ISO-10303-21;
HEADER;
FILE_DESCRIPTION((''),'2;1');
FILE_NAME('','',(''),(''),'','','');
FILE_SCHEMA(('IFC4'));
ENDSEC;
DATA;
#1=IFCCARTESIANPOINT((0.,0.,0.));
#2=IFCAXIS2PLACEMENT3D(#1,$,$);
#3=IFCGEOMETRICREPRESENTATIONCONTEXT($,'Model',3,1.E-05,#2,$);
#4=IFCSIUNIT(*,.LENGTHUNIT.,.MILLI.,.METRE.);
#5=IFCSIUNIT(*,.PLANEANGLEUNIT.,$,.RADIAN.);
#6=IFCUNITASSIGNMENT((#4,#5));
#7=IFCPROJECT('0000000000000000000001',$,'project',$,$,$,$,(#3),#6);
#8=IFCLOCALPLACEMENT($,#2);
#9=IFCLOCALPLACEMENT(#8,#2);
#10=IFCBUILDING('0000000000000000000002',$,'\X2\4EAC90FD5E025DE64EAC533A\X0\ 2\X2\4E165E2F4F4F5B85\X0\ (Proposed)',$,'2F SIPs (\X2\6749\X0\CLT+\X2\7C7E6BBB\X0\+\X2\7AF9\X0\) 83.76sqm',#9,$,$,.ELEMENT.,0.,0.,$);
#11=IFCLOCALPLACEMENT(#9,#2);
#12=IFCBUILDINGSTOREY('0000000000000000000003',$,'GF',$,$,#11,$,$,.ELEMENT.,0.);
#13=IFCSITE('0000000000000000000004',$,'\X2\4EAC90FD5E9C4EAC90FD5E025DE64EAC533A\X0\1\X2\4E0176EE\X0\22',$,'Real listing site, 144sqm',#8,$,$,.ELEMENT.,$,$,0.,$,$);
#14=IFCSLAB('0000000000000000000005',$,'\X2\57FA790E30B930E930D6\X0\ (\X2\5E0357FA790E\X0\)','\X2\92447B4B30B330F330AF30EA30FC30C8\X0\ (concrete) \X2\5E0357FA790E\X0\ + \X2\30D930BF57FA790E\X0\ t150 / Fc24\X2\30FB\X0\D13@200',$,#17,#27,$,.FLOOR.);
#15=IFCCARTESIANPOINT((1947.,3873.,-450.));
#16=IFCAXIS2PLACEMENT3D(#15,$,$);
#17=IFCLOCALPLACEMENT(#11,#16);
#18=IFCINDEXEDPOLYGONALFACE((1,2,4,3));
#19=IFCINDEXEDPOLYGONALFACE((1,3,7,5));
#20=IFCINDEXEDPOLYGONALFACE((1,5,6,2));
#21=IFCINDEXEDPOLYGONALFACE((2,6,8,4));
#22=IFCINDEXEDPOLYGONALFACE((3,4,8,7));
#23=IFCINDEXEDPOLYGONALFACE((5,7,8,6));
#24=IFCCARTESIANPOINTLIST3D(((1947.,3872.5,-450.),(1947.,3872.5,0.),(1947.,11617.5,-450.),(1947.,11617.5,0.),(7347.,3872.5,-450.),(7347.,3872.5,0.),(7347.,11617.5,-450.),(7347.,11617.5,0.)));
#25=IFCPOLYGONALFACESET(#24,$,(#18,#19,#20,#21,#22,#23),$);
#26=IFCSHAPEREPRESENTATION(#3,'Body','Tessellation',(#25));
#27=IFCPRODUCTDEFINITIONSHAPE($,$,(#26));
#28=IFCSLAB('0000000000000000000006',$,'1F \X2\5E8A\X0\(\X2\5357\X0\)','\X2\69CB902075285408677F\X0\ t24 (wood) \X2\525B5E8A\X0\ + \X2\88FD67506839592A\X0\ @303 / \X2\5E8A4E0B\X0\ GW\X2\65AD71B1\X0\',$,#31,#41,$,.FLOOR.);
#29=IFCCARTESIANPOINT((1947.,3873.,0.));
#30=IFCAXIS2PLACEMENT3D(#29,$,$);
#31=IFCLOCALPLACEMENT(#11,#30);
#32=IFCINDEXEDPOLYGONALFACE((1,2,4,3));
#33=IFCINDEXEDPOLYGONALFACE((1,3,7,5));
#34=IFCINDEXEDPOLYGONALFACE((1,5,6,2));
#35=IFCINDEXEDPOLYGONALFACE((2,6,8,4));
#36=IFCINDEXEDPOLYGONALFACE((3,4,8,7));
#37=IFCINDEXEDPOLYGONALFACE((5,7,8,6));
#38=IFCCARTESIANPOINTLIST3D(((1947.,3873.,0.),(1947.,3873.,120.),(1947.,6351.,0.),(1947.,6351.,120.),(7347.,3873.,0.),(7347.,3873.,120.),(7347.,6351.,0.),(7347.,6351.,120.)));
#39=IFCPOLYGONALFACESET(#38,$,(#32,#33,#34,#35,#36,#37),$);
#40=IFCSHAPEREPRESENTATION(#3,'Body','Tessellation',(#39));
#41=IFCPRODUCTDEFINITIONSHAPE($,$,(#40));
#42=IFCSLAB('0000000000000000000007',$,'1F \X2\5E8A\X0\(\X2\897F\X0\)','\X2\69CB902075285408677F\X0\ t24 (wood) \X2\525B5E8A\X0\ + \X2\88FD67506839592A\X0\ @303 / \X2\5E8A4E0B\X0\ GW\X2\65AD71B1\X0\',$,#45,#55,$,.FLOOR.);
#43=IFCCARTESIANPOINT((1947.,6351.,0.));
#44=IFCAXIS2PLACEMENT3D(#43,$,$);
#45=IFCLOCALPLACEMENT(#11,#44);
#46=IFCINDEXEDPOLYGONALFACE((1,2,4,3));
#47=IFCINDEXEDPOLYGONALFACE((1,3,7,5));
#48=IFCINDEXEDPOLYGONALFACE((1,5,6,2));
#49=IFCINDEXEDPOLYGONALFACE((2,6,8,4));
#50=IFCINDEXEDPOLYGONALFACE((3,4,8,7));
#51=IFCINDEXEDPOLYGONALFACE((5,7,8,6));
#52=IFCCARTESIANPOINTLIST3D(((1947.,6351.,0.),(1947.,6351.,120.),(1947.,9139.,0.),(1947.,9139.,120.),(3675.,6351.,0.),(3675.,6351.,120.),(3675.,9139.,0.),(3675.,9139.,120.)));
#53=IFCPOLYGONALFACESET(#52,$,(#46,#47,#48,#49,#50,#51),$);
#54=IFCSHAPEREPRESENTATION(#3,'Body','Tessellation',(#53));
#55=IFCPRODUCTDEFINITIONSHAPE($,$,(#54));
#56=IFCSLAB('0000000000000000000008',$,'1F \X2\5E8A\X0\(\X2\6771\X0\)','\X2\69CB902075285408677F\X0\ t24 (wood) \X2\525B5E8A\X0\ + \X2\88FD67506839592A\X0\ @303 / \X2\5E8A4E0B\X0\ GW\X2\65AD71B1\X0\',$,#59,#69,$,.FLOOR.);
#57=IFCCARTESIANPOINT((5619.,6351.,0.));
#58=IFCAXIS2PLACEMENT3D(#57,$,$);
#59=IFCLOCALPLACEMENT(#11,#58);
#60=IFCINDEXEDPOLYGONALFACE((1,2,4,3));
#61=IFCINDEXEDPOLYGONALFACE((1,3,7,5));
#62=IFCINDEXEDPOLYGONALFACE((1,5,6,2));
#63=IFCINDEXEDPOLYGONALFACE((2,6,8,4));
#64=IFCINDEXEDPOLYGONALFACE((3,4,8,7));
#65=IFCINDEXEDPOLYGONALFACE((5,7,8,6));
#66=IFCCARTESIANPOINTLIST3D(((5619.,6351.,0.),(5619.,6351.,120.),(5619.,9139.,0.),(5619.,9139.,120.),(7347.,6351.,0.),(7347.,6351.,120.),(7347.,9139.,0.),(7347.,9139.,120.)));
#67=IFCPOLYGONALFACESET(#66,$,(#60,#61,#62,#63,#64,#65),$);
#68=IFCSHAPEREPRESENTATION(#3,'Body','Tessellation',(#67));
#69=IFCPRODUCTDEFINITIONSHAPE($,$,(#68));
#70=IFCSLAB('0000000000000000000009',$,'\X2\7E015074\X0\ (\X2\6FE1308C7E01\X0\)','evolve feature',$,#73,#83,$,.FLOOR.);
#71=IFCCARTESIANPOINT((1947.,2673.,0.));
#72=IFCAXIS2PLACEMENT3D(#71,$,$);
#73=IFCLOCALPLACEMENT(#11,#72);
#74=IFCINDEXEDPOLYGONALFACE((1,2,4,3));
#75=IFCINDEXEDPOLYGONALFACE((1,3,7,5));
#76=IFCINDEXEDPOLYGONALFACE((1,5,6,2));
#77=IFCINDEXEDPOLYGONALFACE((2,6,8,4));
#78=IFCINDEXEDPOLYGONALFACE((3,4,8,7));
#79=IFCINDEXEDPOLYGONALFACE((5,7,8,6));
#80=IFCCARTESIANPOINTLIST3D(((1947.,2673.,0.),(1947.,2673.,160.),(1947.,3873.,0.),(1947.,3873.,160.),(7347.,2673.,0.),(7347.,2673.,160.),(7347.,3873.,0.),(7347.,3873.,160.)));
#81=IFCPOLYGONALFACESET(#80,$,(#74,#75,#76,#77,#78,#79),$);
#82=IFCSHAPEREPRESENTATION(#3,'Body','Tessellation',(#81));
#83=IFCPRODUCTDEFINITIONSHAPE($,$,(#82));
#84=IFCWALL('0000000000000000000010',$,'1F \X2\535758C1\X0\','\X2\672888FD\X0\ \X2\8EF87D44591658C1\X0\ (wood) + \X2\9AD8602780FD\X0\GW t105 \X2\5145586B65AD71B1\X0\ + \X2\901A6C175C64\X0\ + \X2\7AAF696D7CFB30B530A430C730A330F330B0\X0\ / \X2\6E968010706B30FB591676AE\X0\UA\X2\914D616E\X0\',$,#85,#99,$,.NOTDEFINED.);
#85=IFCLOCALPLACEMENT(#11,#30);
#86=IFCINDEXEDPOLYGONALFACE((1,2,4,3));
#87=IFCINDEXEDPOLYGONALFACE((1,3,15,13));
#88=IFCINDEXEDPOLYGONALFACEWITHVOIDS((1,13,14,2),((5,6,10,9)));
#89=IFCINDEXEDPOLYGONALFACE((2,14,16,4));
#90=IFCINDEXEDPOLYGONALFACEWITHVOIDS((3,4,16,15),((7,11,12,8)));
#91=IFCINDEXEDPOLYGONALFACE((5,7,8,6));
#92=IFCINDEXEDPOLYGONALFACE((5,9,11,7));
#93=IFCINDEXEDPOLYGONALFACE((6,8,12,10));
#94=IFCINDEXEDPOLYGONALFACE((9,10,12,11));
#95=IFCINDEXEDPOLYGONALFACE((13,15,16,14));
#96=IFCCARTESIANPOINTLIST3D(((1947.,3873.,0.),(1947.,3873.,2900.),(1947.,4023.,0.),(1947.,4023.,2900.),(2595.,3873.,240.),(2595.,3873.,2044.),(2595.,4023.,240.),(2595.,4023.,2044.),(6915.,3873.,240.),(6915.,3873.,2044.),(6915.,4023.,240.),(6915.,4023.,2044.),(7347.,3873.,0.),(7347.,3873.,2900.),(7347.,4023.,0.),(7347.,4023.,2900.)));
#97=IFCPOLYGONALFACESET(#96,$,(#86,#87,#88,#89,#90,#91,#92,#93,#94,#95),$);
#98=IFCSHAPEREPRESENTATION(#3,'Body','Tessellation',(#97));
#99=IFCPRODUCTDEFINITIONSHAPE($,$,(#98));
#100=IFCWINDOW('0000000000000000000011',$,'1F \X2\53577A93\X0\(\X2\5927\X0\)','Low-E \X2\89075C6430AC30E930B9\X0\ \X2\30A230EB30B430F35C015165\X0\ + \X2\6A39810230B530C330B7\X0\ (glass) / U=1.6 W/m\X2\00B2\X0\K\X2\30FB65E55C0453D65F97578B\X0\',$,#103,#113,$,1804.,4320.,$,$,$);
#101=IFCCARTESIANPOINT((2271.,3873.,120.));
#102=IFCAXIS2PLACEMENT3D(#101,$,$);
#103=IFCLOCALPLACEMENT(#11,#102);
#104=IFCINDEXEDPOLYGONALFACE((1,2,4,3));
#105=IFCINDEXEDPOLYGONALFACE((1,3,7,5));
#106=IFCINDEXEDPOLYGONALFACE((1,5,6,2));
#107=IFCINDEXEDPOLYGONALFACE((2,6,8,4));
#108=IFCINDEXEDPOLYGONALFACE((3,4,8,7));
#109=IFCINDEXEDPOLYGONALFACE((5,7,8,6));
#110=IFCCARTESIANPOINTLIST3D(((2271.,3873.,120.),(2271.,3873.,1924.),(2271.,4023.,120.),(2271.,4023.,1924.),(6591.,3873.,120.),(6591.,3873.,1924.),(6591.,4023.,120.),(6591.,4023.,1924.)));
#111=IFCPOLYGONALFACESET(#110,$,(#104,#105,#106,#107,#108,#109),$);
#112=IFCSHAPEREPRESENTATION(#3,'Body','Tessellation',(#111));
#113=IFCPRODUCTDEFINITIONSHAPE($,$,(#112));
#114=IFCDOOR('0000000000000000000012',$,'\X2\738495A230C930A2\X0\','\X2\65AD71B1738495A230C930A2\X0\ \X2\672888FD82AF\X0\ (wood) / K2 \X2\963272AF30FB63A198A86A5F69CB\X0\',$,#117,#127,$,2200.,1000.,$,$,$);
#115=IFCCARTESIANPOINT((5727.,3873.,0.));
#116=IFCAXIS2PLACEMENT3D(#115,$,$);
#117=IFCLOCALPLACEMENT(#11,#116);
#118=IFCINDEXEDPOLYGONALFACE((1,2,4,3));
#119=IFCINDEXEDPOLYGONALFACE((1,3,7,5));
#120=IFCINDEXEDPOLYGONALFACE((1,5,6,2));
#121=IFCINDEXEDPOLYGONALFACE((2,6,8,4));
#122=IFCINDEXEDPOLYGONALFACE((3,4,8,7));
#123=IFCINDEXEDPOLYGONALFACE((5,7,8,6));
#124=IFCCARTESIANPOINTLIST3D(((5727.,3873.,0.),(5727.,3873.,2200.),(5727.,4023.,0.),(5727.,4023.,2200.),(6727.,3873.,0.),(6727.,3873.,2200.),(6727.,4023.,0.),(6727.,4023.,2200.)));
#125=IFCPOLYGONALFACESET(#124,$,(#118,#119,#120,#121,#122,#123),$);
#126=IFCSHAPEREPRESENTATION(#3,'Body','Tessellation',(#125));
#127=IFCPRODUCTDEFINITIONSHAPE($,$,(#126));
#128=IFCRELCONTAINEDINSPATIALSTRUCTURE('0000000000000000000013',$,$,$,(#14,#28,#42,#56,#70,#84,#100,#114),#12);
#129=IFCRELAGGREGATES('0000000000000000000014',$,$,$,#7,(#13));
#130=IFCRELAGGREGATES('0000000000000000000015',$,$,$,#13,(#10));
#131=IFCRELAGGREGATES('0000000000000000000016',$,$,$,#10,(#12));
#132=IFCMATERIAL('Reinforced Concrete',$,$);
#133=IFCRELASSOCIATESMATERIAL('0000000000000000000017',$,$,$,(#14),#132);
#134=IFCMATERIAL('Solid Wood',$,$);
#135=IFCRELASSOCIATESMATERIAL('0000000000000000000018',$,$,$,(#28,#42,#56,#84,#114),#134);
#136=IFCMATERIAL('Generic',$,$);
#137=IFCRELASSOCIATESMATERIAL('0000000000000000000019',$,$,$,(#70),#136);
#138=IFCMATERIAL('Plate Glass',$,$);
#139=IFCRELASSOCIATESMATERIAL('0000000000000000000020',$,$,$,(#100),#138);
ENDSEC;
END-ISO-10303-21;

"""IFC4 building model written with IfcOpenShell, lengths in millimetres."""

from ifc_helpers import new_model, si_unit, frame, frame_2d, origin, place, context, project, spatial, rectangle, extrude, material, element, fill, save


model = new_model("IFC4")

# Units and contexts
model_context = context("Model", 3, precision=1e-05, world=origin())
ifc_project = project(units=[si_unit("LENGTHUNIT", "METRE", prefix="MILLI"), si_unit("PLANEANGLEUNIT", "RADIAN")], contexts=[model_context])

# Site, building, storey
site_placement = place(None, origin())
site = spatial("IfcSite", under=ifc_project, at=site_placement, Name="京都府京都市左京区1丁目22", ObjectType="Real listing site, 144sqm", CompositionType="ELEMENT", RefElevation=0.0)
building_placement = place(site_placement, origin())
building = spatial("IfcBuilding", under=site, at=building_placement, Name="京都市左京区 2世帯住宅 (Proposed)", ObjectType="2F SIPs (杉CLT+籾殻+竹) 83.76sqm", CompositionType="ELEMENT", ElevationOfRefHeight=0.0, ElevationOfTerrain=0.0)
storey_placement = place(building_placement, origin())
storey = spatial("IfcBuildingStorey", under=building, at=storey_placement, Name="GF", CompositionType="ELEMENT", Elevation=0.0)

# Slabs
ifc_material_1 = material(Name="Reinforced Concrete")
slab_1_placement = place(storey_placement, frame((1947.0, 3873.0, -450.0)))
element("IfcSlab", 1, at=slab_1_placement, inside=storey, material=ifc_material_1, Name="基礎スラブ (布基礎)", Description="鉄筋コンクリート (concrete) 布基礎 + ベタ基礎 t150 / Fc24・D13@200", PredefinedType="FLOOR", context=model_context, shape_type="SweptSolid", body=[
    extrude(rectangle(XDim=5400.0, YDim=7745.0, at=frame_2d((2700.0, 3872.0))), frame((1947.0, 3873.0, -450.0)), (0.0, 0.0, 1.0), 450.0),
])
ifc_material_2 = material(Name="Solid Wood")
slab_2_placement = place(storey_placement, frame((1947.0, 3873.0, 0.0)))
element("IfcSlab", 2, at=slab_2_placement, inside=storey, material=ifc_material_2, Name="1F 床(南)", Description="構造用合板 t24 (wood) 剛床 + 製材根太 @303 / 床下 GW断熱", PredefinedType="FLOOR", context=model_context, shape_type="SweptSolid", body=[
    extrude(rectangle(XDim=5400.0, YDim=2478.0, at=frame_2d((2700.0, 1239.0))), frame((1947.0, 3873.0, 0.0)), (0.0, 0.0, 1.0), 120.0),
])
slab_3_placement = place(storey_placement, frame((1947.0, 6351.0, 0.0)))
element("IfcSlab", 3, at=slab_3_placement, inside=storey, material=ifc_material_2, Name="1F 床(西)", Description="構造用合板 t24 (wood) 剛床 + 製材根太 @303 / 床下 GW断熱", PredefinedType="FLOOR", context=model_context, shape_type="SweptSolid", body=[
    extrude(rectangle(XDim=1728.0, YDim=2788.0, at=frame_2d((864.0, 1394.0))), frame((1947.0, 6351.0, 0.0)), (0.0, 0.0, 1.0), 120.0),
])
slab_4_placement = place(storey_placement, frame((5619.0, 6351.0, 0.0)))
element("IfcSlab", 4, at=slab_4_placement, inside=storey, material=ifc_material_2, Name="1F 床(東)", Description="構造用合板 t24 (wood) 剛床 + 製材根太 @303 / 床下 GW断熱", PredefinedType="FLOOR", context=model_context, shape_type="SweptSolid", body=[
    extrude(rectangle(XDim=1728.0, YDim=2788.0, at=frame_2d((864.0, 1394.0))), frame((5619.0, 6351.0, 0.0)), (0.0, 0.0, 1.0), 120.0),
])
ifc_material_3 = material(Name="Generic")
slab_5_placement = place(storey_placement, frame((1947.0, 2673.0, 0.0)))
element("IfcSlab", 5, at=slab_5_placement, inside=storey, material=ifc_material_3, Name="縁側 (濡れ縁)", Description="evolve feature", PredefinedType="FLOOR", context=model_context, shape_type="SweptSolid", body=[
    extrude(rectangle(XDim=5400.0, YDim=1200.0, at=frame_2d((2700.0, 600.0))), frame((1947.0, 2673.0, 0.0)), (0.0, 0.0, 1.0), 160.0),
])

# Wall, openings, window, door
wall_1_placement = place(storey_placement, frame((1947.0, 3873.0, 0.0)))
wall_1 = element("IfcWall", 6, at=wall_1_placement, inside=storey, material=ifc_material_2, Name="1F 南壁", Description="木製 軸組外壁 (wood) + 高性能GW t105 充填断熱 + 通気層 + 窯業系サイディング / 準耐火・外皮UA配慮", PredefinedType="NOTDEFINED", context=model_context, shape_type="SweptSolid", body=[
    extrude(rectangle(XDim=5400.0, YDim=150.0, at=frame_2d((2700.0, 75.0))), frame((1947.0, 3873.0, 0.0)), (0.0, 0.0, 1.0), 2900.0),
])
opening_1_placement = place(storey_placement, frame((2271.0, 3873.0, 120.0)))
opening_1 = element("IfcOpeningElement", 7, at=opening_1_placement, cuts=wall_1, PredefinedType="NOTDEFINED", context=model_context, shape_type="SweptSolid", body=[
    extrude(rectangle(XDim=4320.0, YDim=150.0, at=frame_2d((2160.0, 75.0))), frame((2271.0, 3873.0, 120.0)), (0.0, 0.0, 1.0), 1804.0),
])
opening_2_placement = place(storey_placement, frame((5727.0, 3873.0, 0.0)))
opening_2 = element("IfcOpeningElement", 8, at=opening_2_placement, cuts=wall_1, PredefinedType="NOTDEFINED", context=model_context, shape_type="SweptSolid", body=[
    extrude(rectangle(XDim=1000.0, YDim=150.0, at=frame_2d((500.0, 75.0))), frame((5727.0, 3873.0, 0.0)), (0.0, 0.0, 1.0), 2200.0),
])
ifc_material_4 = material(Name="Plate Glass")
window_1_placement = place(storey_placement, frame((2271.0, 3873.0, 120.0)))
window_1 = element("IfcWindow", 9, at=window_1_placement, inside=storey, material=ifc_material_4, Name="1F 南窓(大)", Description="Low-E 複層ガラス アルゴン封入 + 樹脂サッシ (glass) / U=1.6 W/m²K・日射取得型", OverallHeight=1804.0, OverallWidth=4320.0, context=model_context, shape_type="SweptSolid", body=[
    extrude(rectangle(XDim=4320.0, YDim=150.0, at=frame_2d((2160.0, 75.0))), frame((2271.0, 3873.0, 120.0)), (0.0, 0.0, 1.0), 1804.0),
])
fill(opening_1, window_1)
door_placement = place(storey_placement, frame((5727.0, 3873.0, 0.0)))
door = element("IfcDoor", 10, at=door_placement, inside=storey, material=ifc_material_2, Name="玄関ドア", Description="断熱玄関ドア 木製芯 (wood) / K2 防犯・採風機構", OverallHeight=2200.0, OverallWidth=1000.0, context=model_context, shape_type="SweptSolid", body=[
    extrude(rectangle(XDim=1000.0, YDim=150.0, at=frame_2d((500.0, 75.0))), frame((5727.0, 3873.0, 0.0)), (0.0, 0.0, 1.0), 2200.0),
])
fill(opening_2, door)

save(model, "model.ifc")
